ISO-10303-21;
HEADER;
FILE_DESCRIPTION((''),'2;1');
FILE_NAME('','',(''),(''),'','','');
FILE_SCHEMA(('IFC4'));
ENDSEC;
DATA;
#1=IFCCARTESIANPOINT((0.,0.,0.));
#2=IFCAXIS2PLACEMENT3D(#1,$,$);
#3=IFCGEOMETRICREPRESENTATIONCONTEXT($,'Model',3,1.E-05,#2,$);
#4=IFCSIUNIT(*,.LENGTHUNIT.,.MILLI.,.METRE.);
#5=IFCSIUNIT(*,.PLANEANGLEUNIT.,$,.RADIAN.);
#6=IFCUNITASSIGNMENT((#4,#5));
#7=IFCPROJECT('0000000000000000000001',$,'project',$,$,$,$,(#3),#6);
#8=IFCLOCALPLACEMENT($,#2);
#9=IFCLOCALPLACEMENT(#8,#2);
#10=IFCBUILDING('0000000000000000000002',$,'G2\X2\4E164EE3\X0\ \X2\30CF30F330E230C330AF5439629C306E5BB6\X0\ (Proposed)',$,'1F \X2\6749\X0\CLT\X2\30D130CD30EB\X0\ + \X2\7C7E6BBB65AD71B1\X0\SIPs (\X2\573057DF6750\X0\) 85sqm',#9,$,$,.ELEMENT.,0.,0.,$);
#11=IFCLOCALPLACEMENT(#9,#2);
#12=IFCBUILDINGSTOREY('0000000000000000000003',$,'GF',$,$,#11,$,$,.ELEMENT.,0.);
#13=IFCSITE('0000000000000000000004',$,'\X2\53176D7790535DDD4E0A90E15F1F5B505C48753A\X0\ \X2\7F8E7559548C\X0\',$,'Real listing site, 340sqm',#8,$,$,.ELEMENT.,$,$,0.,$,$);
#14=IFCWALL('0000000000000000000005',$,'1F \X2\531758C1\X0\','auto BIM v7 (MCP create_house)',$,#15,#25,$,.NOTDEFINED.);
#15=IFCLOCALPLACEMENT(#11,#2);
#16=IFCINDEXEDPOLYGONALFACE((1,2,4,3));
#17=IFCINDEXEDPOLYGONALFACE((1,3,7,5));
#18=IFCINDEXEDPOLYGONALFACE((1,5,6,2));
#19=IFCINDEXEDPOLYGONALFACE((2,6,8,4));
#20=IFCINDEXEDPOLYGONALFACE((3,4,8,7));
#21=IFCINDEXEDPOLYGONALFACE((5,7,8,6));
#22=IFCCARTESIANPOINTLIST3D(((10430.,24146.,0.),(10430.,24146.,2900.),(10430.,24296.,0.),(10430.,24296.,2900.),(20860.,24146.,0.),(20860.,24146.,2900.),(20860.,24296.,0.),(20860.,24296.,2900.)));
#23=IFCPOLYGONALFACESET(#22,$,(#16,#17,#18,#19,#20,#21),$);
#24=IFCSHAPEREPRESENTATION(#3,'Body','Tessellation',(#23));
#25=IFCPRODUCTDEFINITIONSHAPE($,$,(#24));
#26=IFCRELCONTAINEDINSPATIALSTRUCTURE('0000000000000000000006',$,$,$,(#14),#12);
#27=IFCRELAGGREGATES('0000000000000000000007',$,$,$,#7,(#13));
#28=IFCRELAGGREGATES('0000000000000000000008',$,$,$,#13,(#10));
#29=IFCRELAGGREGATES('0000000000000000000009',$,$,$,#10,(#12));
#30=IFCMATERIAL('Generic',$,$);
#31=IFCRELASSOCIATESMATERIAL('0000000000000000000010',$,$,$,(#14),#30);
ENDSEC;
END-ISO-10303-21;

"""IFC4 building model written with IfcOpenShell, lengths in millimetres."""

from ifc_helpers import new_model, si_unit, frame, frame_2d, origin, place, context, project, spatial, rectangle, extrude, material, element, save


model = new_model("IFC4")

# Units and contexts
model_context = context("Model", 3, precision=1e-05, world=origin())
ifc_project = project(units=[si_unit("LENGTHUNIT", "METRE", prefix="MILLI"), si_unit("PLANEANGLEUNIT", "RADIAN")], contexts=[model_context])

# Site, building, storey
site_placement = place(None, origin())
site = spatial("IfcSite", under=ifc_project, at=site_placement, Name="北海道川上郡弟子屈町 美留和", ObjectType="Real listing site, 340sqm", CompositionType="ELEMENT", RefElevation=0.0)
building_placement = place(site_placement, origin())
building = spatial("IfcBuilding", under=site, at=building_placement, Name="G2世代 ハンモック吹抜の家 (Proposed)", ObjectType="1F 杉CLTパネル + 籾殻断熱SIPs (地域材) 85sqm", CompositionType="ELEMENT", ElevationOfRefHeight=0.0, ElevationOfTerrain=0.0)
storey_placement = place(building_placement, origin())
storey = spatial("IfcBuildingStorey", under=building, at=storey_placement, Name="GF", CompositionType="ELEMENT", Elevation=0.0)

# Shared definitions
ifc_material = material(Name="Generic")

# Wall
wall_1_placement = place(storey_placement, frame((5215.0, 12073.0, 0.0)))
element("IfcWall", 1, at=wall_1_placement, inside=storey, material=ifc_material, Name="1F 北壁", Description="auto BIM v7 (MCP create_house)", PredefinedType="NOTDEFINED", context=model_context, shape_type="SweptSolid", body=[
    extrude(rectangle(XDim=10430.0, YDim=150.0, at=frame_2d((5215.0, 75.0))), frame((5215.0, 12073.0, 0.0)), (0.0, 0.0, 1.0), 2900.0),
])

save(model, "model.ifc")
